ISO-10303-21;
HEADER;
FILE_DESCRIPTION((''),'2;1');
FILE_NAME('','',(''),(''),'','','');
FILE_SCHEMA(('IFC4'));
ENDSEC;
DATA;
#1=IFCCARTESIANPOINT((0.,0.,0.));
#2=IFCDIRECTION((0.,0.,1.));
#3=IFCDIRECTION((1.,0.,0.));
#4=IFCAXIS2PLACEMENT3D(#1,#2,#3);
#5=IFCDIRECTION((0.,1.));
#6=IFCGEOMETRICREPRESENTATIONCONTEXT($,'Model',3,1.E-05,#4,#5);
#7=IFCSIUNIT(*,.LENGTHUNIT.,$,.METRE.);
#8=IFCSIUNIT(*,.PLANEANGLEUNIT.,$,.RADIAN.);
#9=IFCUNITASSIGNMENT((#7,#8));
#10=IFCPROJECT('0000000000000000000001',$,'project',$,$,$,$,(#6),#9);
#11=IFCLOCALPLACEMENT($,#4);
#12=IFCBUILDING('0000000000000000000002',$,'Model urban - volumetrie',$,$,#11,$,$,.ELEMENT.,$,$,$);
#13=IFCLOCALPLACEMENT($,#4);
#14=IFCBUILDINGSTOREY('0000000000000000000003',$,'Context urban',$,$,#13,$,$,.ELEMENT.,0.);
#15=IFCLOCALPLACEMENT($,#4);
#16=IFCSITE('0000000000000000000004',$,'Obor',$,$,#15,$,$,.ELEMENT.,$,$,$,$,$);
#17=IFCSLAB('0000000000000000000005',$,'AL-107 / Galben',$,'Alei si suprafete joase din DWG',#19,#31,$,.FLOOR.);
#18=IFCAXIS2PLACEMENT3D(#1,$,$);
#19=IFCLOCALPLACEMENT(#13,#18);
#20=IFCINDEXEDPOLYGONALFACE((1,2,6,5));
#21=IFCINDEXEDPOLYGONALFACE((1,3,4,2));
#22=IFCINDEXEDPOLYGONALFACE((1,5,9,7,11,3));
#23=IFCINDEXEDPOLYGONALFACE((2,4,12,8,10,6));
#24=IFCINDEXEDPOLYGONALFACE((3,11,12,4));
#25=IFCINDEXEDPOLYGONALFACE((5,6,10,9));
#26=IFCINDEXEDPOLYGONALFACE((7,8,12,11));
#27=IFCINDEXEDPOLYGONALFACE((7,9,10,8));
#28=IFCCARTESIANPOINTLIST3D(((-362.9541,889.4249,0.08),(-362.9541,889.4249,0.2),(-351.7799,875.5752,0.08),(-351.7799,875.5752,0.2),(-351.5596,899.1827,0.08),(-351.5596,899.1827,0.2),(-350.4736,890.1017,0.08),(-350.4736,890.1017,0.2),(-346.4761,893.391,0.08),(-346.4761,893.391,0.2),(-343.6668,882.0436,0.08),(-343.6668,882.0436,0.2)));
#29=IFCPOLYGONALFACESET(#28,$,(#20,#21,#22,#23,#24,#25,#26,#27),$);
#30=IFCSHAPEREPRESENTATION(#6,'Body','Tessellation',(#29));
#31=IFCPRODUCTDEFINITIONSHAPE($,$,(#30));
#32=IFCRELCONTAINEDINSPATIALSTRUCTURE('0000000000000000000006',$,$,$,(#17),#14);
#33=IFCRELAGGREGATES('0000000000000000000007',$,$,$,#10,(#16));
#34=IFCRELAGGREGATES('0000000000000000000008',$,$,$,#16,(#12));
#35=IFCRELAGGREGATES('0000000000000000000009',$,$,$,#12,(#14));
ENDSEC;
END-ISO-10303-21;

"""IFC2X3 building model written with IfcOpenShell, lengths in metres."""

from ifc_helpers import new_model, si_unit, direction, frame, origin_with_axes, place, context, project, spatial, polyline, outline, extrude, element, save


model = new_model("IFC2X3")

# Units and contexts
model_context = context("Model", 3, precision=1e-05, world=origin_with_axes(), true_north=direction((0.0, 1.0)))
ifc_project = project(units=[si_unit("LENGTHUNIT", "METRE"), si_unit("PLANEANGLEUNIT", "RADIAN")], contexts=[model_context])

# Site, building, storey
site_placement = place(None, origin_with_axes())
site = spatial("IfcSite", under=ifc_project, at=site_placement, Name="Obor", CompositionType="ELEMENT")
building_placement = place(None, origin_with_axes())
building = spatial("IfcBuilding", under=site, at=building_placement, Name="Model urban - volumetrie", CompositionType="ELEMENT")
storey_placement = place(None, origin_with_axes())
storey = spatial("IfcBuildingStorey", under=building, at=storey_placement, Name="Context urban", CompositionType="ELEMENT", Elevation=0.0)

# Slab
slab_1_placement = place(None, origin_with_axes())
element("IfcSlab", 1, at=slab_1_placement, inside=storey, Name="AL-107 / Galben", ObjectType="Alei si suprafete joase din DWG", PredefinedType="FLOOR", context=model_context, shape_type="SweptSolid", body=[
    extrude(outline(polyline([(-362.9541, 889.4249), (-351.7799, 875.5752), (-343.6668, 882.0436), (-350.4736, 890.1017), (-346.4761, 893.391), (-351.5596, 899.1827), (-362.9541, 889.4249)])), frame((0.0, 0.0, 0.08), z_axis=(0.0, 0.0, 1.0), x_axis=(1.0, 0.0, 0.0)), (0.0, 0.0, 1.0), 0.12),
])

save(model, "model.ifc")
